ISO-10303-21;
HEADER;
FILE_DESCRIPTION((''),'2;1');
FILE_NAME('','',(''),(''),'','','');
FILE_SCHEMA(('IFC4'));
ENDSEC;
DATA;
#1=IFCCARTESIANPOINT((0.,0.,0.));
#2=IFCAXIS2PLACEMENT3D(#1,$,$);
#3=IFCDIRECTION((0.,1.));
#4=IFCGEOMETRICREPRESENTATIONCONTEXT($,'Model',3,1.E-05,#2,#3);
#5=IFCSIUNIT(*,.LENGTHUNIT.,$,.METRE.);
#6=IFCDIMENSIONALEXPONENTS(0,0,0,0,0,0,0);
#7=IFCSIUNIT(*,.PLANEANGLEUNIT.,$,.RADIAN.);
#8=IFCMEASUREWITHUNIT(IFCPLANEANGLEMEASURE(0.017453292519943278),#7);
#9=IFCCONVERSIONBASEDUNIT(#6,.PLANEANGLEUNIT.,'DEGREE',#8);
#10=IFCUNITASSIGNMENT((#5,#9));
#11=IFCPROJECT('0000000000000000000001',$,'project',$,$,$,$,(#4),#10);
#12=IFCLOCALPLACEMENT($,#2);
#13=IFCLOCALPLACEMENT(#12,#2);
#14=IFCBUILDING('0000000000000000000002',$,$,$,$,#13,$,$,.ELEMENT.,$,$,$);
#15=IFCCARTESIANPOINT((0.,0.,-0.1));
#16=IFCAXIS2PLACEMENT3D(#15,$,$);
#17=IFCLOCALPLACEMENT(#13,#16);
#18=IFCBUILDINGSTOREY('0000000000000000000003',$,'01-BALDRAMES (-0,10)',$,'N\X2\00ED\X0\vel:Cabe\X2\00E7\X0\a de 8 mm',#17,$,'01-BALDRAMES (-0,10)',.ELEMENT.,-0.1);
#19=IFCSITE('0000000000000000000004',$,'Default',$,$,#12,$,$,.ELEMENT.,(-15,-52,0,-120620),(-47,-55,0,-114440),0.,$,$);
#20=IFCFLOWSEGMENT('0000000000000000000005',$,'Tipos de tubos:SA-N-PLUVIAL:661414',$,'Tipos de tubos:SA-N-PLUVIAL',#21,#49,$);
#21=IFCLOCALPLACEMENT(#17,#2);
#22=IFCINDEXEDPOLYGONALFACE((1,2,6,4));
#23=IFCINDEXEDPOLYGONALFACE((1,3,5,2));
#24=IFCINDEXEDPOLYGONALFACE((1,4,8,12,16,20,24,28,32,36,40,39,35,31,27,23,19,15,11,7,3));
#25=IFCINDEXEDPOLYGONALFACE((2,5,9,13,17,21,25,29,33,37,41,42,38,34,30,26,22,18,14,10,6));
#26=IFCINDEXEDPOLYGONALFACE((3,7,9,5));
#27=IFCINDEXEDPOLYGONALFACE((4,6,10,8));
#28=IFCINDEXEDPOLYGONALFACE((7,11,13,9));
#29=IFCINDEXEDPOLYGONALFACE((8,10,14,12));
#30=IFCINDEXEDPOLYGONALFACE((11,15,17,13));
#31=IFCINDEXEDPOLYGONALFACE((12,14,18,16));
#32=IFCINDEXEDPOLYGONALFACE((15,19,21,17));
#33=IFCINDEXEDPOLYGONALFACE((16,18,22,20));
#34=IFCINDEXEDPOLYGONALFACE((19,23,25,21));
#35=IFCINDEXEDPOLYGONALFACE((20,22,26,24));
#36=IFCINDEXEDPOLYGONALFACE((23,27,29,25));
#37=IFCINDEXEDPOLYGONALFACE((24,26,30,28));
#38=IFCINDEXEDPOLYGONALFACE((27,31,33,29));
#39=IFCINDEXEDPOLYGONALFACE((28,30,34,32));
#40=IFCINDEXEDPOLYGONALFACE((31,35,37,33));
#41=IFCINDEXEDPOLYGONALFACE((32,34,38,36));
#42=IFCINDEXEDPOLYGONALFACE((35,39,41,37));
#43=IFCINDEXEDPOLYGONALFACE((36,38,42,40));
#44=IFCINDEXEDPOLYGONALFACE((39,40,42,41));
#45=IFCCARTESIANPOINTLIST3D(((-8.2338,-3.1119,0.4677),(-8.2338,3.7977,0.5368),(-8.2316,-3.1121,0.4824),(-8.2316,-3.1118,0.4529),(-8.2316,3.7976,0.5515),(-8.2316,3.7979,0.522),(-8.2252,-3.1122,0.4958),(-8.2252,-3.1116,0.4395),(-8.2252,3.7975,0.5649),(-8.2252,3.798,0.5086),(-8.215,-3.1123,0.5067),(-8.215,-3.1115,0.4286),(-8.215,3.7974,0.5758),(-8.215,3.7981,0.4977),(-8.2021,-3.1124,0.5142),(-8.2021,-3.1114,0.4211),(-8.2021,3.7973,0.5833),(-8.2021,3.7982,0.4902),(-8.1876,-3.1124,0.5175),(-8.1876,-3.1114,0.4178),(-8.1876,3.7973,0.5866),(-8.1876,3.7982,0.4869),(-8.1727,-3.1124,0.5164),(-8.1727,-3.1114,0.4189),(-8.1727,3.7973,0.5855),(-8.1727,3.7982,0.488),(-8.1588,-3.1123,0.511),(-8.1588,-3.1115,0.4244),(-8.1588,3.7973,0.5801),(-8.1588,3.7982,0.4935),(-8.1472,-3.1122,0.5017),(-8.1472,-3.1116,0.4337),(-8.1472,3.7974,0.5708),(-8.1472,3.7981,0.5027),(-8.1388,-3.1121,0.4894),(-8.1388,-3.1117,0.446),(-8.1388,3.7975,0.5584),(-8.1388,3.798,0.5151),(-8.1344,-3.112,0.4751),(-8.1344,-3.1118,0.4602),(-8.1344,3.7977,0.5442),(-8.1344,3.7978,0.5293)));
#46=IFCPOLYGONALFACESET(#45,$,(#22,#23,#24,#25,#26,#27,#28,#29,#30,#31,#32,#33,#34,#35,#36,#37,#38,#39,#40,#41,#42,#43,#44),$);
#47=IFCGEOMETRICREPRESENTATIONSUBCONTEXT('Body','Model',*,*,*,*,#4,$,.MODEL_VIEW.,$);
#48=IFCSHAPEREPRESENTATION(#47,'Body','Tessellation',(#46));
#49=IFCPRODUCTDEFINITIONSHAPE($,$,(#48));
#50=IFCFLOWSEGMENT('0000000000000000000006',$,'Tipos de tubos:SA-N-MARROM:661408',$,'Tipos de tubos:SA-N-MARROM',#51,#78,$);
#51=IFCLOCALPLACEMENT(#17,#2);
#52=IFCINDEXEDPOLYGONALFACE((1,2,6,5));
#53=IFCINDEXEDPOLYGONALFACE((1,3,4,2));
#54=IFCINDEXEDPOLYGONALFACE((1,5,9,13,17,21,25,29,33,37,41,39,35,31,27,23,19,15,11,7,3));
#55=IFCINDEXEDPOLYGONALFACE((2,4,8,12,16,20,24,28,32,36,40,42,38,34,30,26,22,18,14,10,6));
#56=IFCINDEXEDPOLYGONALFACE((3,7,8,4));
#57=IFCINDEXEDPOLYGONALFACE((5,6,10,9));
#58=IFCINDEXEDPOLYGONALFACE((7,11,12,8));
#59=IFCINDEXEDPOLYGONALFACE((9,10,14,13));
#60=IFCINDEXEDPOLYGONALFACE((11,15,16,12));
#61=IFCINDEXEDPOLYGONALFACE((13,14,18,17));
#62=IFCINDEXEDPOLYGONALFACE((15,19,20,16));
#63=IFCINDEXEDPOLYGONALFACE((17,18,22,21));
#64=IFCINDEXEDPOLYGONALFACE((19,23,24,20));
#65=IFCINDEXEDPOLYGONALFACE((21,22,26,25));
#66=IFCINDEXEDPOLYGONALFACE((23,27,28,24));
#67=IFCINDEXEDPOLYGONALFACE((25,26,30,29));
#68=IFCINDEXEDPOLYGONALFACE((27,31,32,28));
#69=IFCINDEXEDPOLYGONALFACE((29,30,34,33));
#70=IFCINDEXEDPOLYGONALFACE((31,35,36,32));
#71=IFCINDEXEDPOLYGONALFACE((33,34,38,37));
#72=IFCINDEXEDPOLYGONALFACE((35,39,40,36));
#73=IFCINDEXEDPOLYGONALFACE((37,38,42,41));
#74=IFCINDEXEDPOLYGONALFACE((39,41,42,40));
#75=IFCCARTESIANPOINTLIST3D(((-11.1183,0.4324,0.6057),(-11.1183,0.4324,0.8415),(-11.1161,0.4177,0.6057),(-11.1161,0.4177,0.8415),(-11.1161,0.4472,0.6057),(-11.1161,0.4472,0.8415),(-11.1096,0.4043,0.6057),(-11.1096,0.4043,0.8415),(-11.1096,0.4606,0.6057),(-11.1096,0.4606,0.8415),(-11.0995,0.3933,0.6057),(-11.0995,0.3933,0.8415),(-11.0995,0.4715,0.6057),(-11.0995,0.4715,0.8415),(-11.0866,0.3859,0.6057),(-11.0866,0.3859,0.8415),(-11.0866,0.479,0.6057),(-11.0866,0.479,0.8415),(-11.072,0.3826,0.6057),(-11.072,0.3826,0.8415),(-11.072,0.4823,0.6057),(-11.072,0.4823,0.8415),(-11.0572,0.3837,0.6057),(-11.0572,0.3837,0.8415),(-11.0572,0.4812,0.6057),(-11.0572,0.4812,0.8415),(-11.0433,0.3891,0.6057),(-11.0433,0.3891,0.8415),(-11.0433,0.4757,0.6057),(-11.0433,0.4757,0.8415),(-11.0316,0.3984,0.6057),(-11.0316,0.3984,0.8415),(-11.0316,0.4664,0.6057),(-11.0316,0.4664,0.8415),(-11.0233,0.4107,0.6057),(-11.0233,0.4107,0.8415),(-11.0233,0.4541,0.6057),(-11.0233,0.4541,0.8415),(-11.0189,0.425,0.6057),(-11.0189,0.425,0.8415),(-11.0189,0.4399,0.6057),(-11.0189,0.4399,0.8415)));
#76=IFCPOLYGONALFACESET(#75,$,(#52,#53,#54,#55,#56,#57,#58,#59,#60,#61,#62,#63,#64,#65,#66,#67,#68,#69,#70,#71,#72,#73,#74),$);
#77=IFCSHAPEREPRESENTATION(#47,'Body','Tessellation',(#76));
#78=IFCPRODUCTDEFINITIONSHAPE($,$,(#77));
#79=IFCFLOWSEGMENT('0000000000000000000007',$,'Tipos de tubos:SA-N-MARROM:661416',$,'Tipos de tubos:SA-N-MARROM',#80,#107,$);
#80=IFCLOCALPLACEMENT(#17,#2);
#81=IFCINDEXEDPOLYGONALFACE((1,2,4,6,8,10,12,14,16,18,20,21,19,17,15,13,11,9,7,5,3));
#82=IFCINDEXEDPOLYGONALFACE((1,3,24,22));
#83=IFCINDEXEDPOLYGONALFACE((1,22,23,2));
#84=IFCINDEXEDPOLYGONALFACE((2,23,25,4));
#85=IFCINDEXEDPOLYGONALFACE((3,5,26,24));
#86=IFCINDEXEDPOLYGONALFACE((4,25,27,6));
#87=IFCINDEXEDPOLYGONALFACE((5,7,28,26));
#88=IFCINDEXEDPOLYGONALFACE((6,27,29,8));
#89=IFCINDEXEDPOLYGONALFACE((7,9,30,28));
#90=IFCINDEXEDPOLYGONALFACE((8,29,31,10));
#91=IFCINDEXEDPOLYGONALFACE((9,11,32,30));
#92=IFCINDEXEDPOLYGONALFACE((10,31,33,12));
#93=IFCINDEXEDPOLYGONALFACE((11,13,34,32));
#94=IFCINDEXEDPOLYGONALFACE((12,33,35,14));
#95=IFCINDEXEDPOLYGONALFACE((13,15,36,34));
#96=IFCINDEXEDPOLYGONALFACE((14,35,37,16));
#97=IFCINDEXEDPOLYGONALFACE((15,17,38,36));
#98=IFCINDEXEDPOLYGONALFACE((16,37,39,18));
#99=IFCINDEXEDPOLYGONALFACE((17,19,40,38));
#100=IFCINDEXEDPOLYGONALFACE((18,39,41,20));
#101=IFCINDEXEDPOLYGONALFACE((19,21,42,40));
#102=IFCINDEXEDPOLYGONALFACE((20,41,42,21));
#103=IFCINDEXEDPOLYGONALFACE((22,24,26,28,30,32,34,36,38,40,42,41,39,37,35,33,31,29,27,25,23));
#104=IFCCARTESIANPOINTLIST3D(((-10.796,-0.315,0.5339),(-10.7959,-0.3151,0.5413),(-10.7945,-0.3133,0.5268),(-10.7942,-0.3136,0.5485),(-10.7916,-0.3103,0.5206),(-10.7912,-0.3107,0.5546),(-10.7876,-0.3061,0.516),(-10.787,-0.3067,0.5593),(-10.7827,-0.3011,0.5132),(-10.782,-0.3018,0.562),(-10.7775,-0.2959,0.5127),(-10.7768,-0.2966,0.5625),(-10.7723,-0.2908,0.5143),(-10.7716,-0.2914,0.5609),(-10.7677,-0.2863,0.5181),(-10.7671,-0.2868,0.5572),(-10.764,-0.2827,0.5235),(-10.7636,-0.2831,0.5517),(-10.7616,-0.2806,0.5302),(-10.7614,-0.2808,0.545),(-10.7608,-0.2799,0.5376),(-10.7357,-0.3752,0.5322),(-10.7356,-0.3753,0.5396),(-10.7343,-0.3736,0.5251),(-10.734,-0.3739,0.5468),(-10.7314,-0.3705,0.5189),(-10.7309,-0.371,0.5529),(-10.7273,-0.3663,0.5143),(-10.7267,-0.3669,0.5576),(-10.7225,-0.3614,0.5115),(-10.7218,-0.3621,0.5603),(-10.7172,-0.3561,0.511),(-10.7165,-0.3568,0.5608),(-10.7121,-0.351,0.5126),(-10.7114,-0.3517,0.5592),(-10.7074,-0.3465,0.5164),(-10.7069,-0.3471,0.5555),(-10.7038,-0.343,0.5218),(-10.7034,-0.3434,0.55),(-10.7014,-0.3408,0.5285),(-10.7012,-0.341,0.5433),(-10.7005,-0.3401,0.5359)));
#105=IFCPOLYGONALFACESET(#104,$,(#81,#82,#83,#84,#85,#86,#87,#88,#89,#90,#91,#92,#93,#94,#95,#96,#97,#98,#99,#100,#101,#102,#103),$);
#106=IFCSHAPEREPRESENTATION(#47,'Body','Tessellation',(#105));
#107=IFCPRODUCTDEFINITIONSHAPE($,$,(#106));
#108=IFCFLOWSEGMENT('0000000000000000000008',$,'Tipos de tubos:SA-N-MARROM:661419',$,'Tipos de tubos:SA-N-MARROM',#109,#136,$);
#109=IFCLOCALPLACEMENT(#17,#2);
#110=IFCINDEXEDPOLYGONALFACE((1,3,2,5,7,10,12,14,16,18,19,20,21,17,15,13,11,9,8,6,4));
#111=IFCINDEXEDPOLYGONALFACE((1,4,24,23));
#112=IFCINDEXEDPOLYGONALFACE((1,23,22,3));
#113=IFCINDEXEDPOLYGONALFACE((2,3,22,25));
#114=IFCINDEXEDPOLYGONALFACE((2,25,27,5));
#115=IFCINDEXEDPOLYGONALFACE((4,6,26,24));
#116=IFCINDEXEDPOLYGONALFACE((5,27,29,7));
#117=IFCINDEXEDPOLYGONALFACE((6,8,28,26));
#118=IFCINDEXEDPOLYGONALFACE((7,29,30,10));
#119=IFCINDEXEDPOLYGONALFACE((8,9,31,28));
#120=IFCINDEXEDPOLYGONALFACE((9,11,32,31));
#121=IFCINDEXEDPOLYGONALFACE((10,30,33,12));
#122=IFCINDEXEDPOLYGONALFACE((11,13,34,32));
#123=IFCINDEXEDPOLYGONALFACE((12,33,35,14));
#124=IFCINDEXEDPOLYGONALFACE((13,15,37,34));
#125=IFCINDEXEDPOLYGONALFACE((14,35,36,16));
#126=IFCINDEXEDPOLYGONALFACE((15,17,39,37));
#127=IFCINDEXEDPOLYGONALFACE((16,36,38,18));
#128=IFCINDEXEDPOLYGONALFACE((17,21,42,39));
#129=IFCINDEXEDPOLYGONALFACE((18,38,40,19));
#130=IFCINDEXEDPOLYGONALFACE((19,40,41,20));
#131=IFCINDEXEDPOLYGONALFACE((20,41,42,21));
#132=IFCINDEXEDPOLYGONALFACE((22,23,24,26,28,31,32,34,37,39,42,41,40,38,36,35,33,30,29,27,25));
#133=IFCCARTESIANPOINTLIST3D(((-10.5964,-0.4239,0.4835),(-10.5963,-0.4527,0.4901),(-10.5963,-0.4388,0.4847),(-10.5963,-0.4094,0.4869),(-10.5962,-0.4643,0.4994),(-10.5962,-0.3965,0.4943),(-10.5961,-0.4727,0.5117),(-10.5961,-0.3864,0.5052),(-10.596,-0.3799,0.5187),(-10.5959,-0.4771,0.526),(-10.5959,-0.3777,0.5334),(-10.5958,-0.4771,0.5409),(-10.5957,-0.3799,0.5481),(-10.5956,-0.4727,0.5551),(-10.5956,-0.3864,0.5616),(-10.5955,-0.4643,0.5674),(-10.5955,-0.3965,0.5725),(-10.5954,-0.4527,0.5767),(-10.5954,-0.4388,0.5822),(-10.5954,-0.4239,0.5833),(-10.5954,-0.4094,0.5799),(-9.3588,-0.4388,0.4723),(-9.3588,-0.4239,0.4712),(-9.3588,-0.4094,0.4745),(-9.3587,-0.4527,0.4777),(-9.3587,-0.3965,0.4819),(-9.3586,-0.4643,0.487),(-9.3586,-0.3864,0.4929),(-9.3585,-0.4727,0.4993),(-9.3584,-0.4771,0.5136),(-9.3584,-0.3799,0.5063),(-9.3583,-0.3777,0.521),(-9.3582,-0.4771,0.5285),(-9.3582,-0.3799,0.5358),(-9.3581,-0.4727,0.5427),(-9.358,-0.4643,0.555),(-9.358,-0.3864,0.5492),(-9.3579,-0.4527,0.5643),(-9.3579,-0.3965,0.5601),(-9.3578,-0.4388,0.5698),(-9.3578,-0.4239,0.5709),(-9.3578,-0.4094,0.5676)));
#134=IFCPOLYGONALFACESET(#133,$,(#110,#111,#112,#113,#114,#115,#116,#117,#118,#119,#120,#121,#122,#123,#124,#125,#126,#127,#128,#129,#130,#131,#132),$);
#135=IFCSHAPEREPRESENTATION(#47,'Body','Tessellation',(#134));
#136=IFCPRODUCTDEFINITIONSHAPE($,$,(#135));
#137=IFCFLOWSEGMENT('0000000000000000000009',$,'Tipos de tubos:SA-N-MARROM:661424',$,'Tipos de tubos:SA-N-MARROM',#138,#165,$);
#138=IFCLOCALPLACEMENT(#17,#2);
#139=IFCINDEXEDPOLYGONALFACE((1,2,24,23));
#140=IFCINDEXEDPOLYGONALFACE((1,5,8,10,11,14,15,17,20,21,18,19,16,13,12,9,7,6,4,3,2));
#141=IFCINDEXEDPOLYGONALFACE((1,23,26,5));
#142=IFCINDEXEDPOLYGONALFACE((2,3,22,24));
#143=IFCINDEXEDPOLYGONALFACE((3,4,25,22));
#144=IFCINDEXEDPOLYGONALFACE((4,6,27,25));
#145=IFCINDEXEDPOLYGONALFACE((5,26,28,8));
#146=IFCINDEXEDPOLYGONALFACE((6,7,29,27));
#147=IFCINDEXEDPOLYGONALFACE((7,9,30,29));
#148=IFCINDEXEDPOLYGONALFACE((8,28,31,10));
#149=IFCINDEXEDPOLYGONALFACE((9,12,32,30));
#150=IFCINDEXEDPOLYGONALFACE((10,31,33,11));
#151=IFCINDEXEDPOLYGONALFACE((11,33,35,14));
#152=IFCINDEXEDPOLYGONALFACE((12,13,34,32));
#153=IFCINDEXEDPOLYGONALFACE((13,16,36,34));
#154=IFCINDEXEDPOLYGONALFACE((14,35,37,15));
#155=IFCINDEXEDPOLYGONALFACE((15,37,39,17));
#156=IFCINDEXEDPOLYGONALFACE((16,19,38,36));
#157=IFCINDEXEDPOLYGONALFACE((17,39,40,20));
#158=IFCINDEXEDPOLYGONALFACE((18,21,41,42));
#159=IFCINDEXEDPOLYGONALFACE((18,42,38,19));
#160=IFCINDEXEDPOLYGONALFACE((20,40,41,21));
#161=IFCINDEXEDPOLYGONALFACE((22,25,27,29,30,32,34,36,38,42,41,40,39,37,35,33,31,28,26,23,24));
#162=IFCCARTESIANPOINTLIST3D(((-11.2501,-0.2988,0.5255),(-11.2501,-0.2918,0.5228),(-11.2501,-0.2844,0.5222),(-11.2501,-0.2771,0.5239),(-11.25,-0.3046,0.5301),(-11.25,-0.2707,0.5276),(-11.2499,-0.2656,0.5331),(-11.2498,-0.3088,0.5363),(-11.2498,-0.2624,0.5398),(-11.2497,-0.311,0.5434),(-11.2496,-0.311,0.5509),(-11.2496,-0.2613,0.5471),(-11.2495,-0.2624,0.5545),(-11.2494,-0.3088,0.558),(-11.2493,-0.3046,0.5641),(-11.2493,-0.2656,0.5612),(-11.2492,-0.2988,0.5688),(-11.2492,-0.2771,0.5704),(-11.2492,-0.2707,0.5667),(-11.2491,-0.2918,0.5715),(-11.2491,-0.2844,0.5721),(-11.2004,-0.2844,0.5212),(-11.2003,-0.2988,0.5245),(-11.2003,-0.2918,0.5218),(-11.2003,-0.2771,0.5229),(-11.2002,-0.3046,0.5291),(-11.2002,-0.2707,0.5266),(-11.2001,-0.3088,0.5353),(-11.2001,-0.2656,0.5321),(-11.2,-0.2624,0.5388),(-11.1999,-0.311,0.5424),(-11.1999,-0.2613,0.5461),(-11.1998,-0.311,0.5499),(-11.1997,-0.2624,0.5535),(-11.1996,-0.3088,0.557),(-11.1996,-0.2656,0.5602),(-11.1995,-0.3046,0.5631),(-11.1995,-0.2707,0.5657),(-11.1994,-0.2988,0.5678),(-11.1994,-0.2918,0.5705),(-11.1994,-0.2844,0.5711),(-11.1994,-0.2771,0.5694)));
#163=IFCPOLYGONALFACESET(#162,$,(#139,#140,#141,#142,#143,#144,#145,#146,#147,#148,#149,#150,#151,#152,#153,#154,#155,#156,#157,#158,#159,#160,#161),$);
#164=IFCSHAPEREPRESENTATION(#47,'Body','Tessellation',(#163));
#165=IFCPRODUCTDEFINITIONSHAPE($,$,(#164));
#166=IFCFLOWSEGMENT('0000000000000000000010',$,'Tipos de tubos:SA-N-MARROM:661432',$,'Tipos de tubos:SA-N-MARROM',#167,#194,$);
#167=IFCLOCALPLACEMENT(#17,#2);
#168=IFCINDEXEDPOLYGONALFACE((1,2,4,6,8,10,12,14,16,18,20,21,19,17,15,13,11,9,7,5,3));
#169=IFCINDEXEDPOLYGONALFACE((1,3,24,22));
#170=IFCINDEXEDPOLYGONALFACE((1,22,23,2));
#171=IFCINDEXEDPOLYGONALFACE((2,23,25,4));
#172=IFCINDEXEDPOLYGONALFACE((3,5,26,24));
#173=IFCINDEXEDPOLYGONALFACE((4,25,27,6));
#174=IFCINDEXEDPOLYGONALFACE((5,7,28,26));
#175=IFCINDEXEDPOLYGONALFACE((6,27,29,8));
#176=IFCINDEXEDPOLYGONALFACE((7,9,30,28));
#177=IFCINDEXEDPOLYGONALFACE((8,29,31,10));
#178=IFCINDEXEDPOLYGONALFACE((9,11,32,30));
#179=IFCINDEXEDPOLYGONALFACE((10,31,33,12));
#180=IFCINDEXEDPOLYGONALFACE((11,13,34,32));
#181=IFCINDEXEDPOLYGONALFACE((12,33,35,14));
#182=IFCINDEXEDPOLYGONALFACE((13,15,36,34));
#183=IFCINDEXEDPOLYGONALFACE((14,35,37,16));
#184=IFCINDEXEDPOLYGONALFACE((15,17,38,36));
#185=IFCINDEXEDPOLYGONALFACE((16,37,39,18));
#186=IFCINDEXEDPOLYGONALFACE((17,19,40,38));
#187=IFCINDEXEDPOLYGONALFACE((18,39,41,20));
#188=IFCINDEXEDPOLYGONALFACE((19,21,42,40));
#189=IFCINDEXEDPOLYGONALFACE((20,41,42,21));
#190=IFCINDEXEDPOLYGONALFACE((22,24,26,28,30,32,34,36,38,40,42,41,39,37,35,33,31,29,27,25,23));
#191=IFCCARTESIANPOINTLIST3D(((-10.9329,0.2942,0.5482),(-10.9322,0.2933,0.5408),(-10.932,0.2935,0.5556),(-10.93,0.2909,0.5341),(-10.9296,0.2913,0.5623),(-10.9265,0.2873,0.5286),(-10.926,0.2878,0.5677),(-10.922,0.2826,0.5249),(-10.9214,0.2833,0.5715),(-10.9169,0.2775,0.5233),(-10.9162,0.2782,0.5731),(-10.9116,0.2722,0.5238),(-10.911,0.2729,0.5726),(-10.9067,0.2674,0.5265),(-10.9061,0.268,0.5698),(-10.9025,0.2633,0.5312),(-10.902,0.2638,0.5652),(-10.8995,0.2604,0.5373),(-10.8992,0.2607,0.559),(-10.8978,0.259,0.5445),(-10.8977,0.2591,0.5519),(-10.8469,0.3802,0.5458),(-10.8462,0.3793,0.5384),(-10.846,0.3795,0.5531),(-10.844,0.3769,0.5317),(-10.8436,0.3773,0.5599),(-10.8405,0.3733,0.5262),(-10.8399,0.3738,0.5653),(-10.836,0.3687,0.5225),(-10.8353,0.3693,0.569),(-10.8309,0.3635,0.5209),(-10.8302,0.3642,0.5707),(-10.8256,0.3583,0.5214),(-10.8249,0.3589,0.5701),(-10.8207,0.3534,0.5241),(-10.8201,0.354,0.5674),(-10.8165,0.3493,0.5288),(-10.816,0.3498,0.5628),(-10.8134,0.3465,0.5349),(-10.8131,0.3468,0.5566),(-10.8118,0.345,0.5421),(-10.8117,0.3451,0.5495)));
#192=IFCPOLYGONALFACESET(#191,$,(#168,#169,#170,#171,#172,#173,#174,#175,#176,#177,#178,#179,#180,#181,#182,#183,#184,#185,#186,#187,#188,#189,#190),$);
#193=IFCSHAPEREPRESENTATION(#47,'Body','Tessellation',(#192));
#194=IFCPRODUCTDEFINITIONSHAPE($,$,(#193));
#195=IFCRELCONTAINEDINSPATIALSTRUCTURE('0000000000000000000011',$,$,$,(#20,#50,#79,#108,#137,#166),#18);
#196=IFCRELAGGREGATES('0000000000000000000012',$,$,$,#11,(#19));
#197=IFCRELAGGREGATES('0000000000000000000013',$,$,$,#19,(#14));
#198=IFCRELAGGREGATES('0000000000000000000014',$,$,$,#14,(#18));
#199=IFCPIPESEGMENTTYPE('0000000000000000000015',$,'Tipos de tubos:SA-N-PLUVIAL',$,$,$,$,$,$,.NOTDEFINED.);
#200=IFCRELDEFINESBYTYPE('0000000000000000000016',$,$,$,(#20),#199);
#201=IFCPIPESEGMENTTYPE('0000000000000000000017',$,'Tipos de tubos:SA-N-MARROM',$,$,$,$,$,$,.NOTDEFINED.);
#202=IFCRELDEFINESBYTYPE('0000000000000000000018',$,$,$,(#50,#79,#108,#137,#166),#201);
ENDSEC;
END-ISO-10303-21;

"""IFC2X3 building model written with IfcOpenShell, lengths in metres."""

from ifc_helpers import new_model, entity, si_unit, converted_unit, direction, frame, frame_2d, origin, origin_2d_with_axis, place, context, subcontext, project, spatial, circle, extrude, type_object, element, save


model = new_model("IFC2X3")

# Units and contexts
model_context = context("Model", 3, precision=1e-05, world=origin(), true_north=direction((0.0, 1.0)))
body_context = subcontext(model_context, "Body", "Model", "MODEL_VIEW")
ifc_project = project(units=[si_unit("LENGTHUNIT", "METRE"), converted_unit("PLANEANGLEUNIT", "DEGREE", entity("IfcPlaneAngleMeasure", 0.017453292519943278), si_unit("PLANEANGLEUNIT", "RADIAN"), dimensions=[0, 0, 0, 0, 0, 0, 0])], contexts=[model_context])

# Site, building, storey
site_placement = place(None, origin())
site = spatial("IfcSite", under=ifc_project, at=site_placement, Name="Default", CompositionType="ELEMENT", RefLatitude=(-15, -52, 0, -120620), RefLongitude=(-47, -55, 0, -114440), RefElevation=0.0)
building_placement = place(site_placement, origin())
building = spatial("IfcBuilding", under=site, at=building_placement, CompositionType="ELEMENT")
storey_placement = place(building_placement, frame((0.0, 0.0, -0.1)))
storey = spatial("IfcBuildingStorey", under=building, at=storey_placement, Name="01-BALDRAMES (-0,10)", ObjectType="Nível:Cabeça de 8 mm", LongName="01-BALDRAMES (-0,10)", CompositionType="ELEMENT", Elevation=-0.1)

# Flow segments
pipe_segment_type_1 = type_object("IfcPipeSegmentType", Name="Tipos de tubos:SA-N-PLUVIAL", PredefinedType="NOTDEFINED")
flow_segment_1_placement = place(storey_placement, origin())
element("IfcFlowSegment", 1, at=flow_segment_1_placement, inside=storey, type_object=pipe_segment_type_1, Name="Tipos de tubos:SA-N-PLUVIAL:661414", ObjectType="Tipos de tubos:SA-N-PLUVIAL", context=body_context, shape_type="SweptSolid", body=[
    extrude(circle(Radius=0.05, at=frame_2d((0.0, 0.0), x_axis=(1.0, 0.0))), frame((-8.1838, -3.1119, 0.4677), z_axis=(-0.000001, 0.99995, 0.01), x_axis=(-1.0, -0.000001, 0.0)), (0.0, 0.0, 1.0), 6.91),
])
pipe_segment_type_2 = type_object("IfcPipeSegmentType", Name="Tipos de tubos:SA-N-MARROM", PredefinedType="NOTDEFINED")
flow_segment_2_placement = place(storey_placement, origin())
element("IfcFlowSegment", 2, at=flow_segment_2_placement, inside=storey, type_object=pipe_segment_type_2, Name="Tipos de tubos:SA-N-MARROM:661408", ObjectType="Tipos de tubos:SA-N-MARROM", context=body_context, shape_type="SweptSolid", body=[
    extrude(circle(Radius=0.05, at=frame_2d((0.0, 0.0), x_axis=(1.0, 0.0))), frame((-11.0683, 0.4324, 0.6057), z_axis=(0.0, 0.0, 1.0), x_axis=(-1.0, 0.0, 0.0)), (0.0, 0.0, 1.0), 0.2359),
])
flow_segment_3_placement = place(storey_placement, origin())
element("IfcFlowSegment", 3, at=flow_segment_3_placement, inside=storey, type_object=pipe_segment_type_2, Name="Tipos de tubos:SA-N-MARROM:661416", ObjectType="Tipos de tubos:SA-N-MARROM", context=body_context, shape_type="SweptSolid", body=[
    extrude(circle(Radius=0.025, at=origin_2d_with_axis()), frame((-10.7182, -0.3578, 0.5359), z_axis=(-0.706966, 0.706965, 0.019996), x_axis=(0.707106, 0.707107, 0.0)), (0.0, 0.0, 1.0), 0.0852),
])
flow_segment_4_placement = place(storey_placement, origin())
element("IfcFlowSegment", 4, at=flow_segment_4_placement, inside=storey, type_object=pipe_segment_type_2, Name="Tipos de tubos:SA-N-MARROM:661419", ObjectType="Tipos de tubos:SA-N-MARROM", context=body_context, shape_type="SweptSolid", body=[
    extrude(circle(Radius=0.05, at=frame_2d((0.0, 0.0), x_axis=(1.0, 0.0))), frame((-10.5959, -0.4277, 0.5334), z_axis=(0.99995, 0.000001, -0.01), x_axis=(-0.000001, 1.0, 0.0)), (0.0, 0.0, 1.0), 1.2376),
])
flow_segment_5_placement = place(storey_placement, origin())
element("IfcFlowSegment", 5, at=flow_segment_5_placement, inside=storey, type_object=pipe_segment_type_2, Name="Tipos de tubos:SA-N-MARROM:661424", ObjectType="Tipos de tubos:SA-N-MARROM", context=body_context, shape_type="SweptSolid", body=[
    extrude(circle(Radius=0.025, at=frame_2d((0.0, 0.0), x_axis=(1.0, 0.0))), frame((-11.1999, -0.2863, 0.5461), z_axis=(-0.9998, -0.000001, 0.019996), x_axis=(-0.000001, 1.0, 0.0)), (0.0, 0.0, 1.0), 0.0498),
])
flow_segment_6_placement = place(storey_placement, origin())
element("IfcFlowSegment", 6, at=flow_segment_6_placement, inside=storey, type_object=pipe_segment_type_2, Name="Tipos de tubos:SA-N-MARROM:661432", ObjectType="Tipos de tubos:SA-N-MARROM", context=body_context, shape_type="SweptSolid", body=[
    extrude(circle(Radius=0.025, at=frame_2d((0.0, 0.0), x_axis=(1.0, 0.0))), frame((-10.9152, 0.2765, 0.5482), z_axis=(0.706969, 0.706967, -0.019804), x_axis=(-0.707106, 0.707107, 0.0)), (0.0, 0.0, 1.0), 0.1217),
])

save(model, "model.ifc")
